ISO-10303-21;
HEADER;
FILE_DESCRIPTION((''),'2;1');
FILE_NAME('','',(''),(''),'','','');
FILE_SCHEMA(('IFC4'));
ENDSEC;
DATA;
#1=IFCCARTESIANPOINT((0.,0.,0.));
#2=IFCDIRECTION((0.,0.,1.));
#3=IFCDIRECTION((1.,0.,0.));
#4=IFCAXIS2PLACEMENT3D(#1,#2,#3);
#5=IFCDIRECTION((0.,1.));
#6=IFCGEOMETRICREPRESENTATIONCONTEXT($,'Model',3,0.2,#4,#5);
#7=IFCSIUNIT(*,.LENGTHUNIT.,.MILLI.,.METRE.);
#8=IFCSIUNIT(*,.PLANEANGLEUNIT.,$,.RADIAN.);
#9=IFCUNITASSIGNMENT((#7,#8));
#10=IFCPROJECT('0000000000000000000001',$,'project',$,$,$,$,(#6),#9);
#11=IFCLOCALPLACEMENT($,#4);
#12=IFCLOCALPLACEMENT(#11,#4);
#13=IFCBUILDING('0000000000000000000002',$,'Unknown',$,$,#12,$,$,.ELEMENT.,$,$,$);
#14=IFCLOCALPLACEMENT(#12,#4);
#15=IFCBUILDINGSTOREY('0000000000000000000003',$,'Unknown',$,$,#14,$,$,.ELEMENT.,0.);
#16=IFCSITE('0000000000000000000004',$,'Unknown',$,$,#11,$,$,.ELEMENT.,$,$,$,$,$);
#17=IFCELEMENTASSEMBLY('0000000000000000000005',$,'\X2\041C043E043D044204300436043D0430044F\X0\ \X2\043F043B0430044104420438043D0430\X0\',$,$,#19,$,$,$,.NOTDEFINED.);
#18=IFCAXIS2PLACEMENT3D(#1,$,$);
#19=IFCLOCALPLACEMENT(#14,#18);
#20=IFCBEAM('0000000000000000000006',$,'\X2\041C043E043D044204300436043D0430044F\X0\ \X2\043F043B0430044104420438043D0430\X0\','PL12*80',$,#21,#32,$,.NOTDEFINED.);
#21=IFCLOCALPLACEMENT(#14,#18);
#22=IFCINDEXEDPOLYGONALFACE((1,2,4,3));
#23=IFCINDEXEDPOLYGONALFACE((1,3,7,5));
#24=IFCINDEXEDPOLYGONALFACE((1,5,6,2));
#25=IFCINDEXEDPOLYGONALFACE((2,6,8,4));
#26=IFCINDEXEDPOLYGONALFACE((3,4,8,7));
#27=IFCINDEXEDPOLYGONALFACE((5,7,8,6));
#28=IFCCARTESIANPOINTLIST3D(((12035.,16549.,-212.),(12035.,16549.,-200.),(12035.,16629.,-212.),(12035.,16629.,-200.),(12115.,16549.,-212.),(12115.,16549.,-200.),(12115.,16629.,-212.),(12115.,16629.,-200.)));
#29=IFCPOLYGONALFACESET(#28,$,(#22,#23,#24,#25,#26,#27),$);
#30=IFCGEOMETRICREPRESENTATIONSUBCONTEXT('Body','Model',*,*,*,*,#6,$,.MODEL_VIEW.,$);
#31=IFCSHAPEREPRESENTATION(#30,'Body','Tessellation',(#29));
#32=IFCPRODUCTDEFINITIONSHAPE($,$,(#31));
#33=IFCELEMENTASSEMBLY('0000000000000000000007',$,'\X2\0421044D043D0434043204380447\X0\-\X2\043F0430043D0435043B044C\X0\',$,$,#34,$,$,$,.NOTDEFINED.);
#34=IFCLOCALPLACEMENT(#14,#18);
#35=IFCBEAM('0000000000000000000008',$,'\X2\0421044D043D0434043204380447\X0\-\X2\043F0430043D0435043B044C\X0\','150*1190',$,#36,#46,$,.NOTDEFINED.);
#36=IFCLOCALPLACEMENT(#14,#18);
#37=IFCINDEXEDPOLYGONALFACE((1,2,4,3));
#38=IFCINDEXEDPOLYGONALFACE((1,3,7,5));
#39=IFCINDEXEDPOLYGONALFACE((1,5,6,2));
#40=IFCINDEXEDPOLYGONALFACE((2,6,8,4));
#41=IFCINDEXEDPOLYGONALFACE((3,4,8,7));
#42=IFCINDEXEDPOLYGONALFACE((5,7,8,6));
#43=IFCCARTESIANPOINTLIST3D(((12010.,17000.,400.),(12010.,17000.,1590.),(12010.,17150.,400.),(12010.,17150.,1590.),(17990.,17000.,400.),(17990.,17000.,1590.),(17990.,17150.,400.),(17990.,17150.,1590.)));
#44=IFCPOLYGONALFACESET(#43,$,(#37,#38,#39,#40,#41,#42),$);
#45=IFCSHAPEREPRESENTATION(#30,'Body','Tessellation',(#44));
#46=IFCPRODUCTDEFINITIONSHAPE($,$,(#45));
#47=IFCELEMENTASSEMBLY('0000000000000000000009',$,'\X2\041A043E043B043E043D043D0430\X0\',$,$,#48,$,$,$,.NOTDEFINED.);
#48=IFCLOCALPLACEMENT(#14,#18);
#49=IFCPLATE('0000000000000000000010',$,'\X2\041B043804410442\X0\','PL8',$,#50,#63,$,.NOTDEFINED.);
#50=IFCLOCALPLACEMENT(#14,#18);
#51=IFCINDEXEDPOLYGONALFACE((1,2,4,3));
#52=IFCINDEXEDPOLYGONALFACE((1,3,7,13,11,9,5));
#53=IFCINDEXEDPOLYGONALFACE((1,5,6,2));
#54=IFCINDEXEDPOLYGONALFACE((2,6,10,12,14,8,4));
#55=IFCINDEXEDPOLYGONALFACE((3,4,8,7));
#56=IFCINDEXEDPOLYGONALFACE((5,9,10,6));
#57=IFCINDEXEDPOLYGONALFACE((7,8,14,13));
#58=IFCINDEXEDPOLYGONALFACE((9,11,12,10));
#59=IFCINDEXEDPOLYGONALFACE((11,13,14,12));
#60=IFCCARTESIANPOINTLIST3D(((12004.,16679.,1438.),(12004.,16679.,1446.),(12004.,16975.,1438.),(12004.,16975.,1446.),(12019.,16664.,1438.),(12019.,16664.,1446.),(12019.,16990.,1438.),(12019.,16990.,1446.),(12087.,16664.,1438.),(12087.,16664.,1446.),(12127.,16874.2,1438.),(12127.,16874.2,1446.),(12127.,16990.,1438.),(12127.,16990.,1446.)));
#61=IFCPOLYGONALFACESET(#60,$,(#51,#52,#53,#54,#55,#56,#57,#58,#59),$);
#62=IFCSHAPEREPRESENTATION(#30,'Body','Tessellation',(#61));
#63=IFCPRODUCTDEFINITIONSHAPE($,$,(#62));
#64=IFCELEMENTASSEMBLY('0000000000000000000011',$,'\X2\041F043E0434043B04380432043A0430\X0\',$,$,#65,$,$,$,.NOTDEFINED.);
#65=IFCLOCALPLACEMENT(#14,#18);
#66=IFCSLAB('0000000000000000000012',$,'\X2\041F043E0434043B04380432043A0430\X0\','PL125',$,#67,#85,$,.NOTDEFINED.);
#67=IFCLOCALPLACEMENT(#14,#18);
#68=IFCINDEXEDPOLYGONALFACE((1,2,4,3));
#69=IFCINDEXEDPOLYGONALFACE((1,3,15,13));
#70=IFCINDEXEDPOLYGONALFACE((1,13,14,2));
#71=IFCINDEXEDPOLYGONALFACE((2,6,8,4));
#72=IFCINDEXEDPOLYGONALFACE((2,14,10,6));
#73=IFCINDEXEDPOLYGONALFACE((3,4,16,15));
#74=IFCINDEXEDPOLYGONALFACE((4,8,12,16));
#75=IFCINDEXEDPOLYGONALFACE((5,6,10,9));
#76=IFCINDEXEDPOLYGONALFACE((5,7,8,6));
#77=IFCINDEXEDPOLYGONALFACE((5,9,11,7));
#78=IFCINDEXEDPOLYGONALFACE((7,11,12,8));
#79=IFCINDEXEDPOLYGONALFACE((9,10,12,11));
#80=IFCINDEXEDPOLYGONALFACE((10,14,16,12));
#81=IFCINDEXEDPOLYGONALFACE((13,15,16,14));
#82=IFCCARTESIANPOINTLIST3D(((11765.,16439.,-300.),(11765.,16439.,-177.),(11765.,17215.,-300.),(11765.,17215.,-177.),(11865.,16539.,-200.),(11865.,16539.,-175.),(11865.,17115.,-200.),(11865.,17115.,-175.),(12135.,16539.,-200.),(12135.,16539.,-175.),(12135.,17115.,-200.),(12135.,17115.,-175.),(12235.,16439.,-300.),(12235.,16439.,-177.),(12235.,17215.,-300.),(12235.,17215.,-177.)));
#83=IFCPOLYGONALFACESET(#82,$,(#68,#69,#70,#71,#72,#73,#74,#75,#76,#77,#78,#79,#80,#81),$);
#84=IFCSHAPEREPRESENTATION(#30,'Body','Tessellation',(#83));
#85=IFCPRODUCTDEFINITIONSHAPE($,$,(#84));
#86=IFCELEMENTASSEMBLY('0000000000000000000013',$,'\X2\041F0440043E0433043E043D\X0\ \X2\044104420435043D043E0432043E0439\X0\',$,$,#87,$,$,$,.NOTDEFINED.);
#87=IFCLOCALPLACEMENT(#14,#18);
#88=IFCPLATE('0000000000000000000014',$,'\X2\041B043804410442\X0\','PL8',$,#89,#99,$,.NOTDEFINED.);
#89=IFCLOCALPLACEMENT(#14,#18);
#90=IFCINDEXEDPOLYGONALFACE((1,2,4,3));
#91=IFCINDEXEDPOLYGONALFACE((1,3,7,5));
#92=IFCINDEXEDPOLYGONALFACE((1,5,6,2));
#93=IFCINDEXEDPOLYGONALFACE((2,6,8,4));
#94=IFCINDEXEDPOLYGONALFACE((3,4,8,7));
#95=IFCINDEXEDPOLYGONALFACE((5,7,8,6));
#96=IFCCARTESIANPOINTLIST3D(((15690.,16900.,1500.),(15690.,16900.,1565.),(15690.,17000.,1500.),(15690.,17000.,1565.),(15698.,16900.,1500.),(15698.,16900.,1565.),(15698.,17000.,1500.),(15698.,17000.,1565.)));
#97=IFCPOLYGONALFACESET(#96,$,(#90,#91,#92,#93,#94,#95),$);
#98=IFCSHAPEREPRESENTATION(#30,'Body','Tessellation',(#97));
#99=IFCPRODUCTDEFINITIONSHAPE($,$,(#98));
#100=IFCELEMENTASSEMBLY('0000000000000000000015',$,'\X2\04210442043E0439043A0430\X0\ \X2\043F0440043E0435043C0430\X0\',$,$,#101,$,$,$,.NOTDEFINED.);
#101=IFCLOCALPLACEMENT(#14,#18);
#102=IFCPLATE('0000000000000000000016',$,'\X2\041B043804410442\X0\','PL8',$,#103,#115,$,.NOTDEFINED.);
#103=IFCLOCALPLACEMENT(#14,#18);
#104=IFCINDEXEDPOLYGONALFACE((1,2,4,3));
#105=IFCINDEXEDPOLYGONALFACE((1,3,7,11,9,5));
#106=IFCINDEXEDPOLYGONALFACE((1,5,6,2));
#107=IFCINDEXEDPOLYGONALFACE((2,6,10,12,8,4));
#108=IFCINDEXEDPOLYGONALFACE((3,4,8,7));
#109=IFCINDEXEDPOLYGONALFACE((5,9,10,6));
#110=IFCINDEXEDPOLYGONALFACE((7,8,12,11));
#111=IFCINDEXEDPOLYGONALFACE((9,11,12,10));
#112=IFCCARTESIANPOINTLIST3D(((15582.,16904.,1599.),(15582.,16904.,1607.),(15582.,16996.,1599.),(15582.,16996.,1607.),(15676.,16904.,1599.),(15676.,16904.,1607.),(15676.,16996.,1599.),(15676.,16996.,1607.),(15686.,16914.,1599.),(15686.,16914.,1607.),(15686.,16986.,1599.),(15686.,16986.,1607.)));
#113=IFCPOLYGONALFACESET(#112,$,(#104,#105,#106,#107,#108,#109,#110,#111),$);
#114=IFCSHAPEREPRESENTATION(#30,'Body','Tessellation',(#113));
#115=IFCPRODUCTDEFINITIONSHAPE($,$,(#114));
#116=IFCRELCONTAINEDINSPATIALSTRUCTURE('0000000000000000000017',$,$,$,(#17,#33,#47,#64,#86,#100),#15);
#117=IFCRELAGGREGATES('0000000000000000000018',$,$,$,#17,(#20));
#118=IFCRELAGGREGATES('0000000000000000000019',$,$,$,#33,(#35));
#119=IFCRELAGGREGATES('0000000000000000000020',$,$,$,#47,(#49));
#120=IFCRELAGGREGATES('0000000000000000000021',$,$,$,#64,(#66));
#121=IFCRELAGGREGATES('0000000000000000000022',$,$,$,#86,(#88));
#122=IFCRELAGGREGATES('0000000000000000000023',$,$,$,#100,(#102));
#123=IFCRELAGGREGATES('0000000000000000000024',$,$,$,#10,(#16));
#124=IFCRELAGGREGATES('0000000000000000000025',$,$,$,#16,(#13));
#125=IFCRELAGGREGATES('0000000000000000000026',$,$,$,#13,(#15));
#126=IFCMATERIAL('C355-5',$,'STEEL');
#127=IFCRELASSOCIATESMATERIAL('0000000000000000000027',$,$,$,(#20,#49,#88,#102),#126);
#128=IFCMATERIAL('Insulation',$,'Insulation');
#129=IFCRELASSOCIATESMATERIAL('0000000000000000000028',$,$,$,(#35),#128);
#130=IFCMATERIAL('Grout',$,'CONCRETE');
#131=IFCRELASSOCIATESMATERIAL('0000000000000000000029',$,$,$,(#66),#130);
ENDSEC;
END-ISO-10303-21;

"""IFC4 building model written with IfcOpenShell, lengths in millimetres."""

from ifc_helpers import new_model, si_unit, direction, frame, origin_with_axes, place, context, subcontext, project, spatial, line, indexed_curve, outline, extrude, material, element, aggregate, save


model = new_model("IFC4")

# Units and contexts
model_context = context("Model", 3, precision=0.2, world=origin_with_axes(), true_north=direction((0.0, 1.0)))
body_context = subcontext(model_context, "Body", "Model", "MODEL_VIEW")
ifc_project = project(units=[si_unit("LENGTHUNIT", "METRE", prefix="MILLI"), si_unit("PLANEANGLEUNIT", "RADIAN")], contexts=[model_context])

# Site, building, storey
site_placement = place(None, origin_with_axes())
site = spatial("IfcSite", under=ifc_project, at=site_placement, Name="Unknown", CompositionType="ELEMENT")
building_placement = place(site_placement, origin_with_axes())
building = spatial("IfcBuilding", under=site, at=building_placement, Name="Unknown", CompositionType="ELEMENT")
storey_placement = place(building_placement, origin_with_axes())
storey = spatial("IfcBuildingStorey", under=building, at=storey_placement, Name="Unknown", CompositionType="ELEMENT", Elevation=0.0)

# Shared definitions
ifc_material_1 = material(Name="C355-5", Category="STEEL")

# Element assemblies, beams
assembly_1_placement = place(storey_placement, frame((12115.0, 16589.0, -206.0), z_axis=(0.0, 0.0, -1.0), x_axis=(-1.0, 0.0, 0.0)))
assembly_1 = element("IfcElementAssembly", 1, at=assembly_1_placement, inside=storey, Name="Монтажная пластина", PredefinedType="NOTDEFINED")
beam_1_placement = place(assembly_1_placement, origin_with_axes())
beam_1 = element("IfcBeam", 2, at=beam_1_placement, material=ifc_material_1, Name="Монтажная пластина", Description="PL12*80", PredefinedType="NOTDEFINED", context=body_context, shape_type="SolidModel", body=[
    extrude(outline(indexed_curve([(-6.0, -40.0), (6.0, -40.0), (6.0, 40.0), (-6.0, 40.0)], segments=[line(1, 2, 3, 4, 1)])), frame((0.0, 0.0, 0.0), z_axis=(-1.0, 0.0, 0.0), x_axis=(0.0, 0.0, 1.0)), (0.0, 0.0, -1.0), 80.0),
])
aggregate(assembly_1, [beam_1])
assembly_2_placement = place(storey_placement, frame((12010.0, 17075.0, 995.0), z_axis=(0.0, 0.0, -1.0), x_axis=(1.0, 0.0, 0.0)))
assembly_2 = element("IfcElementAssembly", 3, at=assembly_2_placement, inside=storey, Name="Сэндвич-панель", PredefinedType="NOTDEFINED")
ifc_material_2 = material(Name="Insulation", Category="Insulation")
beam_2_placement = place(assembly_2_placement, origin_with_axes())
beam_2 = element("IfcBeam", 4, at=beam_2_placement, material=ifc_material_2, Name="Сэндвич-панель", Description="150*1190", PredefinedType="NOTDEFINED", context=body_context, shape_type="SolidModel", body=[
    extrude(outline(indexed_curve([(-595.0, -75.0), (595.0, -75.0), (595.0, 75.0), (-595.0, 75.0)], segments=[line(1, 2, 3, 4, 1)])), frame((0.0, 0.0, 0.0), z_axis=(-1.0, 0.0, 0.0), x_axis=(0.0, 0.0, 1.0)), (0.0, 0.0, -1.0), 5980.0),
])
aggregate(assembly_2, [beam_2])

# Element assembly, plate
assembly_3_placement = place(storey_placement, frame((12000.0, 16827.0, -200.0), z_axis=(-1.0, 0.0, 0.0), x_axis=(0.0, 0.0, 1.0)))
assembly_3 = element("IfcElementAssembly", 5, at=assembly_3_placement, inside=storey, Name="Колонна", PredefinedType="NOTDEFINED")
plate_1_placement = place(assembly_3_placement, frame((1642.0, -163.0, -4.0), z_axis=(1.0, 0.0, 0.0), x_axis=(0.0, 0.0, -1.0)))
plate_1 = element("IfcPlate", 6, at=plate_1_placement, material=ifc_material_1, Name="Лист", Description="PL8", PredefinedType="NOTDEFINED", context=body_context, shape_type="SolidModel", body=[
    extrude(outline(indexed_curve([(0.0, 15.0), (15.0, 0.0), (83.0, 0.0), (123.0, 210.2), (123.0, 326.0), (15.0, 326.0), (0.0, 311.0)], segments=[line(1, 2, 3, 4, 5, 6, 7, 1)])), frame((0.0, 0.0, 4.0), z_axis=(0.0, 0.0, 1.0), x_axis=(1.0, 0.0, 0.0)), (0.0, 0.0, -1.0), 8.0),
])
aggregate(assembly_3, [plate_1])

# Element assembly, slab, voiding features
assembly_4_placement = place(storey_placement, frame((12235.0, 16439.0, -237.5), z_axis=(0.0, 0.0, -1.0), x_axis=(-1.0, 0.0, 0.0)))
assembly_4 = element("IfcElementAssembly", 7, at=assembly_4_placement, inside=storey, Name="Подливка", PredefinedType="NOTDEFINED")
ifc_material_3 = material(Name="Grout", Category="CONCRETE")
slab_placement = place(assembly_4_placement, origin_with_axes())
slab = element("IfcSlab", 8, at=slab_placement, material=ifc_material_3, Name="Подливка", Description="PL125", PredefinedType="NOTDEFINED", context=body_context, shape_type="SolidModel", body=[
    extrude(outline(indexed_curve([(0.0, 0.0), (470.0, 0.0), (470.0, 776.0), (0.0, 776.0)], segments=[line(1, 2, 3, 4, 1)])), frame((0.0, 0.0, 62.5), z_axis=(0.0, 0.0, 1.0), x_axis=(1.0, 0.0, 0.0)), (0.0, 0.0, -1.0), 125.0),
])
voiding_feature_1_placement = place(slab_placement, frame((235.0, 0.0, -62.5), z_axis=(1.0, 0.0, 0.0), x_axis=(0.0, 1.0, 0.0)))
element("IfcVoidingFeature", 9, at=voiding_feature_1_placement, cuts=slab, Name="PLATE", PredefinedType="HOLE", context=body_context, shape_type="SolidModel", body=[
    extrude(outline(indexed_curve([(0.0, 0.0), (100.0, 0.0), (0.0, 2.0)], segments=[line(1, 2, 3, 1)])), frame((0.0, 0.0, 247.0), z_axis=(0.0, 0.0, 1.0), x_axis=(1.0, 0.0, 0.0)), (0.0, 0.0, -1.0), 494.0),
])
voiding_feature_2_placement = place(slab_placement, frame((235.0, 776.0, -62.5), z_axis=(-1.0, 0.0, 0.0), x_axis=(0.0, -1.0, 0.0)))
element("IfcVoidingFeature", 10, at=voiding_feature_2_placement, cuts=slab, Name="PLATE", PredefinedType="HOLE", context=body_context, shape_type="SolidModel", body=[
    extrude(outline(indexed_curve([(0.0, 0.0), (100.0, 0.0), (0.0, 2.0)], segments=[line(1, 2, 3, 1)])), frame((0.0, 0.0, 247.0), z_axis=(0.0, 0.0, 1.0), x_axis=(1.0, 0.0, 0.0)), (0.0, 0.0, -1.0), 494.0),
])
voiding_feature_3_placement = place(slab_placement, frame((470.0, 388.0, -62.5), z_axis=(0.0, 1.0, 0.0), x_axis=(-1.0, 0.0, 0.0)))
element("IfcVoidingFeature", 11, at=voiding_feature_3_placement, cuts=slab, Name="PLATE", PredefinedType="HOLE", context=body_context, shape_type="SolidModel", body=[
    extrude(outline(indexed_curve([(0.0, 0.0), (100.0, 0.0), (0.0, 2.0)], segments=[line(1, 2, 3, 1)])), frame((0.0, 0.0, 400.0), z_axis=(0.0, 0.0, 1.0), x_axis=(1.0, 0.0, 0.0)), (0.0, 0.0, -1.0), 800.0),
])
voiding_feature_4_placement = place(slab_placement, frame((0.0, 388.0, -62.5), z_axis=(0.0, -1.0, 0.0), x_axis=(1.0, 0.0, 0.0)))
element("IfcVoidingFeature", 12, at=voiding_feature_4_placement, cuts=slab, Name="PLATE", PredefinedType="HOLE", context=body_context, shape_type="SolidModel", body=[
    extrude(outline(indexed_curve([(0.0, 0.0), (100.0, 0.0), (0.0, 2.0)], segments=[line(1, 2, 3, 1)])), frame((0.0, 0.0, 400.0), z_axis=(0.0, 0.0, 1.0), x_axis=(1.0, 0.0, 0.0)), (0.0, 0.0, -1.0), 800.0),
])
voiding_feature_5_placement = place(slab_placement, frame((235.0, 676.0, -50.0), z_axis=(0.0, 0.0, 1.0), x_axis=(0.0, -1.0, 0.0)))
element("IfcVoidingFeature", 13, at=voiding_feature_5_placement, cuts=slab, Name="Пластина", PredefinedType="HOLE", context=body_context, shape_type="SolidModel", body=[
    extrude(outline(indexed_curve([(-12.5, -135.0), (12.5, -135.0), (12.5, 135.0), (-12.5, 135.0)], segments=[line(1, 2, 3, 4, 1)])), frame((0.0, 0.0, 0.0), z_axis=(-1.0, 0.0, 0.0), x_axis=(0.0, 0.0, 1.0)), (0.0, 0.0, -1.0), 576.0),
])
aggregate(assembly_4, [slab])

# Element assembly, plate
assembly_5_placement = place(storey_placement, frame((18000.0, 16950.0, 1450.0), z_axis=(0.0, 0.0, -1.0), x_axis=(-1.0, 0.0, 0.0)))
assembly_5 = element("IfcElementAssembly", 14, at=assembly_5_placement, inside=storey, Name="Прогон стеновой", PredefinedType="NOTDEFINED")
plate_2_placement = place(assembly_5_placement, frame((2306.0, 50.0, -50.0), z_axis=(-1.0, 0.0, 0.0), x_axis=(0.0, 0.0, -1.0)))
plate_2 = element("IfcPlate", 15, at=plate_2_placement, material=ifc_material_1, Name="Лист", Description="PL8", PredefinedType="NOTDEFINED", context=body_context, shape_type="SolidModel", body=[
    extrude(outline(indexed_curve([(0.0, 0.0), (65.0, 0.0), (65.0, 100.0), (0.0, 100.0)], segments=[line(1, 2, 3, 4, 1)])), frame((0.0, 0.0, 4.0), z_axis=(0.0, 0.0, 1.0), x_axis=(1.0, 0.0, 0.0)), (0.0, 0.0, -1.0), 8.0),
])
aggregate(assembly_5, [plate_2])

# Element assembly, plate
assembly_6_placement = place(storey_placement, frame((15640.0, 16950.0, 1500.0), z_axis=(-1.0, 0.0, 0.0), x_axis=(0.0, 0.0, 1.0)))
assembly_6 = element("IfcElementAssembly", 16, at=assembly_6_placement, inside=storey, Name="Стойка проема", PredefinedType="NOTDEFINED")
plate_3_placement = place(assembly_6_placement, frame((103.0, 46.0, -46.0), z_axis=(-1.0, 0.0, 0.0), x_axis=(0.0, -1.0, 0.0)))
plate_3 = element("IfcPlate", 17, at=plate_3_placement, material=ifc_material_1, Name="Лист", Description="PL8", PredefinedType="NOTDEFINED", context=body_context, shape_type="SolidModel", body=[
    extrude(outline(indexed_curve([(0.0, 10.0), (10.0, 0.0), (82.0, 0.0), (92.0, 10.0), (92.0, 104.0), (0.0, 104.0)], segments=[line(1, 2, 3, 4, 5, 6, 1)])), frame((0.0, 0.0, 4.0), z_axis=(0.0, 0.0, 1.0), x_axis=(1.0, 0.0, 0.0)), (0.0, 0.0, -1.0), 8.0),
])
aggregate(assembly_6, [plate_3])

save(model, "model.ifc")
